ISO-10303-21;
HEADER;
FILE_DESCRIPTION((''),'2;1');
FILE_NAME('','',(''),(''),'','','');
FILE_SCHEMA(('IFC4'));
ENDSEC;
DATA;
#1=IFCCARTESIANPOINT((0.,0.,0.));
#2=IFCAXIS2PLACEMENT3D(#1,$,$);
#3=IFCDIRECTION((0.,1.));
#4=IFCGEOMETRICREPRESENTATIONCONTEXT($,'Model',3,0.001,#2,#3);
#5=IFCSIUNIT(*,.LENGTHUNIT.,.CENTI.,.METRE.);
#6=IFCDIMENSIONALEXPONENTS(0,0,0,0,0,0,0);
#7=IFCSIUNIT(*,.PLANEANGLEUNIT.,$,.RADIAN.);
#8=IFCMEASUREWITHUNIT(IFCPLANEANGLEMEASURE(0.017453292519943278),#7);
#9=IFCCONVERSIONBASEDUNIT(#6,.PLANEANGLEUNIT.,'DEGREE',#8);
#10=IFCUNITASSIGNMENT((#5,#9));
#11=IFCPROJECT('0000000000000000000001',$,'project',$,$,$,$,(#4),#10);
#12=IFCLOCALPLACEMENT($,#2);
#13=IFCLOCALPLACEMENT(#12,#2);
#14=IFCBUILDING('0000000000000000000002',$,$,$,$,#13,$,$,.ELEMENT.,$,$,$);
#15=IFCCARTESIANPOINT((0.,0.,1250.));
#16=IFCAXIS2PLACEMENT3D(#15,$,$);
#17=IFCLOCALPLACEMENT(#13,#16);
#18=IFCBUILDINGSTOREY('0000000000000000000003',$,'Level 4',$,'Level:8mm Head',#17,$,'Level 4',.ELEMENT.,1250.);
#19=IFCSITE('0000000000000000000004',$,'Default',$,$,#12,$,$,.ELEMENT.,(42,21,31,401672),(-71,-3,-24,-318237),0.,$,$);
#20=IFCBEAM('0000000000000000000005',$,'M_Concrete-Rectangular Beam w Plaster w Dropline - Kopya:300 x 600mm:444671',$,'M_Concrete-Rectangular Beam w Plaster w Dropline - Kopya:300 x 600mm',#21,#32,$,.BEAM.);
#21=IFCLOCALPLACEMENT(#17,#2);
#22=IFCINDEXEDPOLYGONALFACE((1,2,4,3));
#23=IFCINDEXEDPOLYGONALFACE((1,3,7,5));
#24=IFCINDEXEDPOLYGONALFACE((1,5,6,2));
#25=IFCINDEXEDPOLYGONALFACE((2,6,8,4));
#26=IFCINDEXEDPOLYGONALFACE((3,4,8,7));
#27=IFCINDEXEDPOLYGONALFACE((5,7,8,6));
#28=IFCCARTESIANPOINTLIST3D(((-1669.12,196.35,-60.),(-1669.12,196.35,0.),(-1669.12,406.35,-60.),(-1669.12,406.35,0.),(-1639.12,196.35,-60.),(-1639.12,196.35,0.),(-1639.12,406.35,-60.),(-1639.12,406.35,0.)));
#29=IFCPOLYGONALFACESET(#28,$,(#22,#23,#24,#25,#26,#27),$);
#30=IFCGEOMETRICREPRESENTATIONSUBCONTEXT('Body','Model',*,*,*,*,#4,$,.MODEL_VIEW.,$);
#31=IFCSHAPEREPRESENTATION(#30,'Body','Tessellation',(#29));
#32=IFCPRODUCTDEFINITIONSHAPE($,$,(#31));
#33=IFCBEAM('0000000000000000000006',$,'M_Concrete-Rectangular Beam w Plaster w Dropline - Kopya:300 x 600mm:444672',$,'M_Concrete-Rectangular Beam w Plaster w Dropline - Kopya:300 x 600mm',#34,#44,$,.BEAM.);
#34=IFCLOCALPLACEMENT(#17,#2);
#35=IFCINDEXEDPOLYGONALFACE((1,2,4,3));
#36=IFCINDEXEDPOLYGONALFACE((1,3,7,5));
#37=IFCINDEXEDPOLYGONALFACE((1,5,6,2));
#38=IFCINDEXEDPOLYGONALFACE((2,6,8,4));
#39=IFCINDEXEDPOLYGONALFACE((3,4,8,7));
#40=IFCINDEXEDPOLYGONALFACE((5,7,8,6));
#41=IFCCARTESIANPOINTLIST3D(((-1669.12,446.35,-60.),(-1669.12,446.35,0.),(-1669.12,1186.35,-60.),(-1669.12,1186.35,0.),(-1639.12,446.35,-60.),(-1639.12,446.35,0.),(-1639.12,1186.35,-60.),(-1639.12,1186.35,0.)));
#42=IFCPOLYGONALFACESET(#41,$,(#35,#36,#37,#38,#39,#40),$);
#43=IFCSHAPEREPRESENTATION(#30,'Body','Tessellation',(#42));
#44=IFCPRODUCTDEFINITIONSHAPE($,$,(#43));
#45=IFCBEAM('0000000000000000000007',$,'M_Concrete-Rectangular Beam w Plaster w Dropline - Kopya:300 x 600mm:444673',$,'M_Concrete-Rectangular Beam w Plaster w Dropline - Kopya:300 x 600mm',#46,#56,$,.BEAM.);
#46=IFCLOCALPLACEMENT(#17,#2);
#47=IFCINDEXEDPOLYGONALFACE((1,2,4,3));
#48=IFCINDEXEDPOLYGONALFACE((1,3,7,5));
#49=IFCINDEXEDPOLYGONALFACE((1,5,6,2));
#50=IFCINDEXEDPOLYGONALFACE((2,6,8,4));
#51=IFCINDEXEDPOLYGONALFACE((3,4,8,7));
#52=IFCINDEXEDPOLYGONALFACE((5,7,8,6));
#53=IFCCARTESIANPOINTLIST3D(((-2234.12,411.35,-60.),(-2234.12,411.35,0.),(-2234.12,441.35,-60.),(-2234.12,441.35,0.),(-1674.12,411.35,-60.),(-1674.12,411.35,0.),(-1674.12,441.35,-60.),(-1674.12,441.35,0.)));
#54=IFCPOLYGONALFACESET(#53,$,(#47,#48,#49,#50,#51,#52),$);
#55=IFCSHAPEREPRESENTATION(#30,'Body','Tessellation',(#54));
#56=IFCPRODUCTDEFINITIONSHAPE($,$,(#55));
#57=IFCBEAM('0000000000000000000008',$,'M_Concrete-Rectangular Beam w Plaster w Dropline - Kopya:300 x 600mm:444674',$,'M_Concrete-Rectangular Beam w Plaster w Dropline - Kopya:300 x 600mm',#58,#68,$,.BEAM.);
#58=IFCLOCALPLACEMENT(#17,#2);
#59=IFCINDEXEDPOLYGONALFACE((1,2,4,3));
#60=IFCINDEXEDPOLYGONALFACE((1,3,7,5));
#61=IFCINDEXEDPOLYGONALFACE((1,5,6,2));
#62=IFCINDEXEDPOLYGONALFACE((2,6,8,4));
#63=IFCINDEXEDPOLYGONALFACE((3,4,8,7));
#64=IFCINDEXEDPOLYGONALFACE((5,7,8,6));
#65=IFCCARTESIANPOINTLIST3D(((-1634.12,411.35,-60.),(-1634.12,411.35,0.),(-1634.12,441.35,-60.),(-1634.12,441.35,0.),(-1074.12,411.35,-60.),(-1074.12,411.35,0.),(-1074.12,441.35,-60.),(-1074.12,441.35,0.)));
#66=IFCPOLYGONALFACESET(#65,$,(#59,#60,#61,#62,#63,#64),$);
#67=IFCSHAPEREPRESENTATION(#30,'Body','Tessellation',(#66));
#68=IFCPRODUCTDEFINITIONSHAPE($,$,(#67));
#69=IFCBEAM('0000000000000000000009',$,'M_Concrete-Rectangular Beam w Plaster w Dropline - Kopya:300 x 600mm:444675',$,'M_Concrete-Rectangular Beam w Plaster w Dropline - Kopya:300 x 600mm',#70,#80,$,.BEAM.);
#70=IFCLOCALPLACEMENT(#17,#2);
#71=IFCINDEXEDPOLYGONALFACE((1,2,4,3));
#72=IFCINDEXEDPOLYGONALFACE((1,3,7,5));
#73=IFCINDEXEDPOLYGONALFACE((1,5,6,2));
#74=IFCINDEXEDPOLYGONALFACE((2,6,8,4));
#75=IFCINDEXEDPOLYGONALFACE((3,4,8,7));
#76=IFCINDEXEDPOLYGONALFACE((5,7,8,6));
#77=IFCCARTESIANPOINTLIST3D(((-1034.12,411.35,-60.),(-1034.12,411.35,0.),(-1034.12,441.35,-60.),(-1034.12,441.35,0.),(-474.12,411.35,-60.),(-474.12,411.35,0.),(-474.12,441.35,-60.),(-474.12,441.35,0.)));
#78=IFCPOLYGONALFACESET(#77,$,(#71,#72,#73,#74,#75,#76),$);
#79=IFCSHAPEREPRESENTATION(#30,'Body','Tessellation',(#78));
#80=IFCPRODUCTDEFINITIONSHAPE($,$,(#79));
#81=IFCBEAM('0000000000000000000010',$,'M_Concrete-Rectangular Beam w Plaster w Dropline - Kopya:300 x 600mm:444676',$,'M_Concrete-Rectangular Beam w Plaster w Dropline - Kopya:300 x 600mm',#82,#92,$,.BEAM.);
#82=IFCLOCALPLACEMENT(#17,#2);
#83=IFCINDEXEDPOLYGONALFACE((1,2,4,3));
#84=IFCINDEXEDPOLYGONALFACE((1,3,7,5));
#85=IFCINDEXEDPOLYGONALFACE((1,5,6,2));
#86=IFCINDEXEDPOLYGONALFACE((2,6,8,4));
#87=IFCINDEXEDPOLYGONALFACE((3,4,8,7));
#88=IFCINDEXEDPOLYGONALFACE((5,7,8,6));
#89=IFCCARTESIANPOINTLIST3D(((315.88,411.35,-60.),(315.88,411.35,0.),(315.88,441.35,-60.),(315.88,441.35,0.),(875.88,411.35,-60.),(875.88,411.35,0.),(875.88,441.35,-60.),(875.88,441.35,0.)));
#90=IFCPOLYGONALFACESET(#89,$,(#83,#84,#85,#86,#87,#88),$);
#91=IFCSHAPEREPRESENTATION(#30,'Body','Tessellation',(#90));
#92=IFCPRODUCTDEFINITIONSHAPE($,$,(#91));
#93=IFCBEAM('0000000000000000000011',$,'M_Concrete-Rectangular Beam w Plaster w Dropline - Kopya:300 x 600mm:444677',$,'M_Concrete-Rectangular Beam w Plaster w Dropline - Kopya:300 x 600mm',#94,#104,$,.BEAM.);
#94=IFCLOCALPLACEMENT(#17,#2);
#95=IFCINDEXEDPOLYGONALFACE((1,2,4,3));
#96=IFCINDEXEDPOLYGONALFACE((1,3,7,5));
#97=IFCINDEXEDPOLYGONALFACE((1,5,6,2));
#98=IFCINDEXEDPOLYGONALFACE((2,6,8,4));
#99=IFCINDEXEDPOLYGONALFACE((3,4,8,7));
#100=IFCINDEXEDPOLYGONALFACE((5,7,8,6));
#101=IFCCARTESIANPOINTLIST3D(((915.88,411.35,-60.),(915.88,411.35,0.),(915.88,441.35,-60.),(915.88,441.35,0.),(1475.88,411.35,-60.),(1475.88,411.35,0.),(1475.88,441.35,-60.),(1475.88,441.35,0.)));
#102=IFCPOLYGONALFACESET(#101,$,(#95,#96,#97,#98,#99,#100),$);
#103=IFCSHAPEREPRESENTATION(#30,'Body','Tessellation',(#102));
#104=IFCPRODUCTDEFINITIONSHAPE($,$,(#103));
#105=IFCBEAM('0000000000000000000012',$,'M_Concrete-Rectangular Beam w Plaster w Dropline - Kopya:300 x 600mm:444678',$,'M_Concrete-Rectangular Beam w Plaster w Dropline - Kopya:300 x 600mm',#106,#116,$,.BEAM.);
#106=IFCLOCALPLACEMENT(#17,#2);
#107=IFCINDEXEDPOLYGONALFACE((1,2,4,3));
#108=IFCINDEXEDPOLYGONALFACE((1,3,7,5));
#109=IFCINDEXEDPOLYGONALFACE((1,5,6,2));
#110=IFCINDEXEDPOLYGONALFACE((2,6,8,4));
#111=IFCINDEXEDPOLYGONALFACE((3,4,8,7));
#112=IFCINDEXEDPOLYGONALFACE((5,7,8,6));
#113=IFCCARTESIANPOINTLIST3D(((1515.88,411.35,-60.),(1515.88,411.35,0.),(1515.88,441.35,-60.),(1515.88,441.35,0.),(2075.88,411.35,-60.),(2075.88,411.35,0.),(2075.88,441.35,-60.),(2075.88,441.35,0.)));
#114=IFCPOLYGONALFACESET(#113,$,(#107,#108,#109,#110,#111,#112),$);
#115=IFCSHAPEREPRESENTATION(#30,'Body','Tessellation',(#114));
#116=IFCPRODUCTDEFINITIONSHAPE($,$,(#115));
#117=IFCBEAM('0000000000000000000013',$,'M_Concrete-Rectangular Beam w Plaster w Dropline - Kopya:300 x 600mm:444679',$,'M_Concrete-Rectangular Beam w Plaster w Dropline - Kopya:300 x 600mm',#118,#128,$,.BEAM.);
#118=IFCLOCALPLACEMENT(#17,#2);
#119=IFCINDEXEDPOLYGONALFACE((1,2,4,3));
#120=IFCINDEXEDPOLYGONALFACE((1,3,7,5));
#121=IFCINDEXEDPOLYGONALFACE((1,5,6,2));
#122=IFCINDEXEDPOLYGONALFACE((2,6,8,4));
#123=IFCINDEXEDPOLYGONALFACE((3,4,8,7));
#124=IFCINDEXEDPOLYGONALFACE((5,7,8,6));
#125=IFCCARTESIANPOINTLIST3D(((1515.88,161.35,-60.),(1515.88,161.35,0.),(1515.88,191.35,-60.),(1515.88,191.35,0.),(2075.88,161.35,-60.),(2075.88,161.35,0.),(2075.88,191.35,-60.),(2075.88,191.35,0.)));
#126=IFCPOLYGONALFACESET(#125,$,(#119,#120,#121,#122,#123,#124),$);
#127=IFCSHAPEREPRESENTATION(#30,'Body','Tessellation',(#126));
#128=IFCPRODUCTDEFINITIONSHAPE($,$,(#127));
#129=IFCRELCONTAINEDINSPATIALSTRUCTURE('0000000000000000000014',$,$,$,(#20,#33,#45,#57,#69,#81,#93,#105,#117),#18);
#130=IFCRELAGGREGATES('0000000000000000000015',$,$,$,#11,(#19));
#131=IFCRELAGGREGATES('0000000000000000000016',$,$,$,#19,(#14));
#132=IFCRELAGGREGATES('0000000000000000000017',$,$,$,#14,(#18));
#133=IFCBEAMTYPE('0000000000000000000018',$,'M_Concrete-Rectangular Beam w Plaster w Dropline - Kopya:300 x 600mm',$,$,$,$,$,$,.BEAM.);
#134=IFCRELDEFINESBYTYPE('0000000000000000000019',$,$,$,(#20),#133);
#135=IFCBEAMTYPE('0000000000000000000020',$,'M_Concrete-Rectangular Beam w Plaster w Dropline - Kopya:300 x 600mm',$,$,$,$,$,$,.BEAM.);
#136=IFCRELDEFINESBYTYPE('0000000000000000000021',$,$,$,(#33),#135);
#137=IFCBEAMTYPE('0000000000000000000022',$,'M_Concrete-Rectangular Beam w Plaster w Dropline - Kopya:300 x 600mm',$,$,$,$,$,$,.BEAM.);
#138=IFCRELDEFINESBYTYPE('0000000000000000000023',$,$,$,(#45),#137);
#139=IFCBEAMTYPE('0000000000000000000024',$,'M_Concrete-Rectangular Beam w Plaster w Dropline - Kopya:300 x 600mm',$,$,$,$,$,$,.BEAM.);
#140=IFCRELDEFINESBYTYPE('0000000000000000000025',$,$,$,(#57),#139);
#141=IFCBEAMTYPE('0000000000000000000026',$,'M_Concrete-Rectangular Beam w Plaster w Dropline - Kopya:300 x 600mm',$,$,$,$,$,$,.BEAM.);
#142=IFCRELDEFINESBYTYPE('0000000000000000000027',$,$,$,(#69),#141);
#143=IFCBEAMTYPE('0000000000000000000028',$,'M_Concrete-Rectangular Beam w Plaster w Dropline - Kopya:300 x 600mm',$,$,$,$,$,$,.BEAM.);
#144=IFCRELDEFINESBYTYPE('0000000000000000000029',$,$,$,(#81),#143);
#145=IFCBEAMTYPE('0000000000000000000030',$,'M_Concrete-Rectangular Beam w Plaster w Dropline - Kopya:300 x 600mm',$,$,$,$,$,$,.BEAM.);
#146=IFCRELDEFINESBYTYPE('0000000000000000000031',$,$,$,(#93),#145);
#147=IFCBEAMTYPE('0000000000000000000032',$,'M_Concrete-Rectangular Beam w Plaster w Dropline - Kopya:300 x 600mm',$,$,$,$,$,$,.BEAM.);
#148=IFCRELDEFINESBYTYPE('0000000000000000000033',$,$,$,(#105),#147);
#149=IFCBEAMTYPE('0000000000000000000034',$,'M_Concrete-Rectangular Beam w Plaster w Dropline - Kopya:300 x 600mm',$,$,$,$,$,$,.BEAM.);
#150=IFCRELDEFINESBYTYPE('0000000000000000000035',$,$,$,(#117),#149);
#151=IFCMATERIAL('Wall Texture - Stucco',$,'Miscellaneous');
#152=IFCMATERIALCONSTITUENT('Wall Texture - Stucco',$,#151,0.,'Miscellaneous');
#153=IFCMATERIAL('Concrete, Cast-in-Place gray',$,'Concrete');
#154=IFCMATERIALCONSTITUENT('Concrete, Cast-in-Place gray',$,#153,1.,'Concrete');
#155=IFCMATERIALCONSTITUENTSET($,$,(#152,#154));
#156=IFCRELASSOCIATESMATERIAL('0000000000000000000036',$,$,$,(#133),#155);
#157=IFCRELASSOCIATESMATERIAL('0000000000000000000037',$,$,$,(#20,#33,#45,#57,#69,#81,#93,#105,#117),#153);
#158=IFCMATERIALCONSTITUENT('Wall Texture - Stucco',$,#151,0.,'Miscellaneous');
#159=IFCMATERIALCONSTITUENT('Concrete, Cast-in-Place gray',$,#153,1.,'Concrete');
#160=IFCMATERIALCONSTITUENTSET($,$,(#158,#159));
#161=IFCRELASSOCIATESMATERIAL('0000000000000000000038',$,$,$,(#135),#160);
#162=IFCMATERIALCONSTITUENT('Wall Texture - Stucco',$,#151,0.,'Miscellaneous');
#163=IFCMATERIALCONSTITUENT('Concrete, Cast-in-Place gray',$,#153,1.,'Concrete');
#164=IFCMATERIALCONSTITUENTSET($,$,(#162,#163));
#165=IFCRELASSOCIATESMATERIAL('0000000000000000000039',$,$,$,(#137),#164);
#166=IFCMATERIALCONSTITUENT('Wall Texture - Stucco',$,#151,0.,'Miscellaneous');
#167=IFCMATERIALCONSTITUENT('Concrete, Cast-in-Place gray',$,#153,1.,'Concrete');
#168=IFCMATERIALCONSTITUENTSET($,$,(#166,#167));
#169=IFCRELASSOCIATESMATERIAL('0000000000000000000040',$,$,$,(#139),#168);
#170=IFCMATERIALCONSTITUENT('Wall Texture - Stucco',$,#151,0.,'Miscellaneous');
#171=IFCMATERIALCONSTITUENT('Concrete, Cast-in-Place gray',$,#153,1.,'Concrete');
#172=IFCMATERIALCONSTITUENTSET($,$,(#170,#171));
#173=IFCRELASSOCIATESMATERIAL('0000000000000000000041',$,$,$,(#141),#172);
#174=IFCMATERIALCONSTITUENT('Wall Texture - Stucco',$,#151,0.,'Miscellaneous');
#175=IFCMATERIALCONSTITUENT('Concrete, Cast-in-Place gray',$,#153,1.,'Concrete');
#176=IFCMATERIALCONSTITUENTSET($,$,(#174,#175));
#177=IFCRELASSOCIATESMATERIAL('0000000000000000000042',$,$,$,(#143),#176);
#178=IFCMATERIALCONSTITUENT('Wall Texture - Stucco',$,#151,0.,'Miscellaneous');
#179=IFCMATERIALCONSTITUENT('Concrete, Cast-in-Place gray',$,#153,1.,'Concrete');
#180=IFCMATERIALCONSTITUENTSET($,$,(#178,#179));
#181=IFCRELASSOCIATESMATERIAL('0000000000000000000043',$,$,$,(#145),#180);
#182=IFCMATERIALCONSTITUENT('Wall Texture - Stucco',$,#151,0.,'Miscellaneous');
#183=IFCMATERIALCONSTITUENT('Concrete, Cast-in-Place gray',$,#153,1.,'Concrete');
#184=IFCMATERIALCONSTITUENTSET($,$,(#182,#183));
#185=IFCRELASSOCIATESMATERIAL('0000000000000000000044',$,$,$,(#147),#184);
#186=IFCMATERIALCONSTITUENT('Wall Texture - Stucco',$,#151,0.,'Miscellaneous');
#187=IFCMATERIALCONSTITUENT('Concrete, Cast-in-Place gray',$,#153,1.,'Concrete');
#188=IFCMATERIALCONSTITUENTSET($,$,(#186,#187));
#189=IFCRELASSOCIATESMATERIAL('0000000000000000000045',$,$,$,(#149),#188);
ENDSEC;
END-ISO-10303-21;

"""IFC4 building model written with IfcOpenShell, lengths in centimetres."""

from ifc_helpers import new_model, entity, si_unit, converted_unit, direction, frame, origin, place, context, subcontext, project, spatial, indexed_curve, outline, extrude, source, transform, mapped, material, constituent, constituent_set, type_object, type_shapes, element, save


model = new_model("IFC4")

# Units and contexts
model_context = context("Model", 3, precision=0.001, world=origin(), true_north=direction((0.0, 1.0)))
body_context = subcontext(model_context, "Body", "Model", "MODEL_VIEW")
ifc_project = project(units=[si_unit("LENGTHUNIT", "METRE", prefix="CENTI"), converted_unit("PLANEANGLEUNIT", "DEGREE", entity("IfcPlaneAngleMeasure", 0.017453292519943278), si_unit("PLANEANGLEUNIT", "RADIAN"), dimensions=[0, 0, 0, 0, 0, 0, 0])], contexts=[model_context])

# Site, building, storey
site_placement = place(None, origin())
site = spatial("IfcSite", under=ifc_project, at=site_placement, Name="Default", CompositionType="ELEMENT", RefLatitude=(42, 21, 31, 401672), RefLongitude=(-71, -3, -24, -318237), RefElevation=0.0)
building_placement = place(site_placement, origin())
building = spatial("IfcBuilding", under=site, at=building_placement, CompositionType="ELEMENT")
storey_placement = place(building_placement, frame((0.0, 0.0, 1250.0)))
storey = spatial("IfcBuildingStorey", under=building, at=storey_placement, Name="Level 4", ObjectType="Level:8mm Head", LongName="Level 4", CompositionType="ELEMENT", Elevation=1250.0)

# Shared definitions
ifc_material_1 = material(Name="Concrete, Cast-in-Place gray", Category="Concrete")

# Beams
ifc_material_2 = material(Name="Wall Texture - Stucco", Category="Miscellaneous")
ifc_constituent_1 = constituent(ifc_material_2, Name="Wall Texture - Stucco", Category="Miscellaneous", fraction=0.0)
ifc_constituent_2 = constituent(ifc_material_1, Name="Concrete, Cast-in-Place gray", Category="Concrete", fraction=1.0)
ifc_constituent_set_1 = constituent_set(constituents=[ifc_constituent_1, ifc_constituent_2])
beam_type_1 = type_object("IfcBeamType", Name="M_Concrete-Rectangular Beam w Plaster w Dropline - Kopya:300 x 600mm", PredefinedType="BEAM", material=ifc_constituent_set_1)
shared_shape_1 = source(origin(), body_context, "Body", "SweptSolid", [
    extrude(outline(indexed_curve([(-15.0, -30.0), (15.0, -30.0), (15.0, 30.0), (-15.0, 30.0), (-15.0, -30.0)], self_intersect=False)), frame((-1654.12, 196.35, 1220.0), z_axis=(0.0, 1.0, 0.0), x_axis=(-1.0, 0.0, 0.0)), (0.0, 0.0, 1.0), 210.0),
])
type_shapes(beam_type_1, [shared_shape_1])
beam_1_placement = place(storey_placement, frame((0.0, 0.0, -1250.0)))
element("IfcBeam", 1, at=beam_1_placement, inside=storey, type_object=beam_type_1, material=ifc_material_1, Name="M_Concrete-Rectangular Beam w Plaster w Dropline - Kopya:300 x 600mm:444671", ObjectType="M_Concrete-Rectangular Beam w Plaster w Dropline - Kopya:300 x 600mm", PredefinedType="BEAM", context=body_context, shape_type="MappedRepresentation", body=[
    mapped(shared_shape_1, transform((0.0, 0.0, 0.0), scale=1.0)),
])
ifc_constituent_3 = constituent(ifc_material_2, Name="Wall Texture - Stucco", Category="Miscellaneous", fraction=0.0)
ifc_constituent_4 = constituent(ifc_material_1, Name="Concrete, Cast-in-Place gray", Category="Concrete", fraction=1.0)
ifc_constituent_set_2 = constituent_set(constituents=[ifc_constituent_3, ifc_constituent_4])
beam_type_2 = type_object("IfcBeamType", Name="M_Concrete-Rectangular Beam w Plaster w Dropline - Kopya:300 x 600mm", PredefinedType="BEAM", material=ifc_constituent_set_2)
shared_shape_2 = source(origin(), body_context, "Body", "SweptSolid", [
    extrude(outline(indexed_curve([(-15.0, -30.0), (15.0, -30.0), (15.0, 30.0), (-15.0, 30.0), (-15.0, -30.0)], self_intersect=False)), frame((-1654.12, 446.35, 1220.0), z_axis=(0.0, 1.0, 0.0), x_axis=(-1.0, 0.0, 0.0)), (0.0, 0.0, 1.0), 740.0),
])
type_shapes(beam_type_2, [shared_shape_2])
beam_2_placement = place(storey_placement, frame((0.0, 0.0, -1250.0)))
element("IfcBeam", 2, at=beam_2_placement, inside=storey, type_object=beam_type_2, material=ifc_material_1, Name="M_Concrete-Rectangular Beam w Plaster w Dropline - Kopya:300 x 600mm:444672", ObjectType="M_Concrete-Rectangular Beam w Plaster w Dropline - Kopya:300 x 600mm", PredefinedType="BEAM", context=body_context, shape_type="MappedRepresentation", body=[
    mapped(shared_shape_2, transform((0.0, 0.0, 0.0), scale=1.0)),
])
ifc_constituent_5 = constituent(ifc_material_2, Name="Wall Texture - Stucco", Category="Miscellaneous", fraction=0.0)
ifc_constituent_6 = constituent(ifc_material_1, Name="Concrete, Cast-in-Place gray", Category="Concrete", fraction=1.0)
ifc_constituent_set_3 = constituent_set(constituents=[ifc_constituent_5, ifc_constituent_6])
beam_type_3 = type_object("IfcBeamType", Name="M_Concrete-Rectangular Beam w Plaster w Dropline - Kopya:300 x 600mm", PredefinedType="BEAM", material=ifc_constituent_set_3)
shared_shape_3 = source(origin(), body_context, "Body", "SweptSolid", [
    extrude(outline(indexed_curve([(-30.0, -15.0), (30.0, -15.0), (30.0, 15.0), (-30.0, 15.0), (-30.0, -15.0)], self_intersect=False)), frame((-2234.12, 426.35, 1220.0), z_axis=(1.0, 0.0, 0.0), x_axis=(0.0, 0.0, -1.0)), (0.0, 0.0, 1.0), 560.0),
])
type_shapes(beam_type_3, [shared_shape_3])
beam_3_placement = place(storey_placement, frame((0.0, 0.0, -1250.0)))
element("IfcBeam", 3, at=beam_3_placement, inside=storey, type_object=beam_type_3, material=ifc_material_1, Name="M_Concrete-Rectangular Beam w Plaster w Dropline - Kopya:300 x 600mm:444673", ObjectType="M_Concrete-Rectangular Beam w Plaster w Dropline - Kopya:300 x 600mm", PredefinedType="BEAM", context=body_context, shape_type="MappedRepresentation", body=[
    mapped(shared_shape_3, transform((0.0, 0.0, 0.0), scale=1.0)),
])
ifc_constituent_7 = constituent(ifc_material_2, Name="Wall Texture - Stucco", Category="Miscellaneous", fraction=0.0)
ifc_constituent_8 = constituent(ifc_material_1, Name="Concrete, Cast-in-Place gray", Category="Concrete", fraction=1.0)
ifc_constituent_set_4 = constituent_set(constituents=[ifc_constituent_7, ifc_constituent_8])
beam_type_4 = type_object("IfcBeamType", Name="M_Concrete-Rectangular Beam w Plaster w Dropline - Kopya:300 x 600mm", PredefinedType="BEAM", material=ifc_constituent_set_4)
shared_shape_4 = source(origin(), body_context, "Body", "SweptSolid", [
    extrude(outline(indexed_curve([(-30.0, -15.0), (30.0, -15.0), (30.0, 15.0), (-30.0, 15.0), (-30.0, -15.0)], self_intersect=False)), frame((-1634.12, 426.35, 1220.0), z_axis=(1.0, 0.0, 0.0), x_axis=(0.0, 0.0, -1.0)), (0.0, 0.0, 1.0), 560.0),
])
type_shapes(beam_type_4, [shared_shape_4])
beam_4_placement = place(storey_placement, frame((0.0, 0.0, -1250.0)))
element("IfcBeam", 4, at=beam_4_placement, inside=storey, type_object=beam_type_4, material=ifc_material_1, Name="M_Concrete-Rectangular Beam w Plaster w Dropline - Kopya:300 x 600mm:444674", ObjectType="M_Concrete-Rectangular Beam w Plaster w Dropline - Kopya:300 x 600mm", PredefinedType="BEAM", context=body_context, shape_type="MappedRepresentation", body=[
    mapped(shared_shape_4, transform((0.0, 0.0, 0.0), scale=1.0)),
])
ifc_constituent_9 = constituent(ifc_material_2, Name="Wall Texture - Stucco", Category="Miscellaneous", fraction=0.0)
ifc_constituent_10 = constituent(ifc_material_1, Name="Concrete, Cast-in-Place gray", Category="Concrete", fraction=1.0)
ifc_constituent_set_5 = constituent_set(constituents=[ifc_constituent_9, ifc_constituent_10])
beam_type_5 = type_object("IfcBeamType", Name="M_Concrete-Rectangular Beam w Plaster w Dropline - Kopya:300 x 600mm", PredefinedType="BEAM", material=ifc_constituent_set_5)
shared_shape_5 = source(origin(), body_context, "Body", "SweptSolid", [
    extrude(outline(indexed_curve([(-30.0, -15.0), (30.0, -15.0), (30.0, 15.0), (-30.0, 15.0), (-30.0, -15.0)], self_intersect=False)), frame((-1034.12, 426.35, 1220.0), z_axis=(1.0, 0.0, 0.0), x_axis=(0.0, 0.0, -1.0)), (0.0, 0.0, 1.0), 560.0),
])
type_shapes(beam_type_5, [shared_shape_5])
beam_5_placement = place(storey_placement, frame((0.0, 0.0, -1250.0)))
element("IfcBeam", 5, at=beam_5_placement, inside=storey, type_object=beam_type_5, material=ifc_material_1, Name="M_Concrete-Rectangular Beam w Plaster w Dropline - Kopya:300 x 600mm:444675", ObjectType="M_Concrete-Rectangular Beam w Plaster w Dropline - Kopya:300 x 600mm", PredefinedType="BEAM", context=body_context, shape_type="MappedRepresentation", body=[
    mapped(shared_shape_5, transform((0.0, 0.0, 0.0), scale=1.0)),
])
ifc_constituent_11 = constituent(ifc_material_2, Name="Wall Texture - Stucco", Category="Miscellaneous", fraction=0.0)
ifc_constituent_12 = constituent(ifc_material_1, Name="Concrete, Cast-in-Place gray", Category="Concrete", fraction=1.0)
ifc_constituent_set_6 = constituent_set(constituents=[ifc_constituent_11, ifc_constituent_12])
beam_type_6 = type_object("IfcBeamType", Name="M_Concrete-Rectangular Beam w Plaster w Dropline - Kopya:300 x 600mm", PredefinedType="BEAM", material=ifc_constituent_set_6)
shared_shape_6 = source(origin(), body_context, "Body", "SweptSolid", [
    extrude(outline(indexed_curve([(-30.0, -15.0), (30.0, -15.0), (30.0, 15.0), (-30.0, 15.0), (-30.0, -15.0)], self_intersect=False)), frame((315.88, 426.35, 1220.0), z_axis=(1.0, 0.0, 0.0), x_axis=(0.0, 0.0, -1.0)), (0.0, 0.0, 1.0), 560.0),
])
type_shapes(beam_type_6, [shared_shape_6])
beam_6_placement = place(storey_placement, frame((0.0, 0.0, -1250.0)))
element("IfcBeam", 6, at=beam_6_placement, inside=storey, type_object=beam_type_6, material=ifc_material_1, Name="M_Concrete-Rectangular Beam w Plaster w Dropline - Kopya:300 x 600mm:444676", ObjectType="M_Concrete-Rectangular Beam w Plaster w Dropline - Kopya:300 x 600mm", PredefinedType="BEAM", context=body_context, shape_type="MappedRepresentation", body=[
    mapped(shared_shape_6, transform((0.0, 0.0, 0.0), scale=1.0)),
])
ifc_constituent_13 = constituent(ifc_material_2, Name="Wall Texture - Stucco", Category="Miscellaneous", fraction=0.0)
ifc_constituent_14 = constituent(ifc_material_1, Name="Concrete, Cast-in-Place gray", Category="Concrete", fraction=1.0)
ifc_constituent_set_7 = constituent_set(constituents=[ifc_constituent_13, ifc_constituent_14])
beam_type_7 = type_object("IfcBeamType", Name="M_Concrete-Rectangular Beam w Plaster w Dropline - Kopya:300 x 600mm", PredefinedType="BEAM", material=ifc_constituent_set_7)
shared_shape_7 = source(origin(), body_context, "Body", "SweptSolid", [
    extrude(outline(indexed_curve([(-30.0, -15.0), (30.0, -15.0), (30.0, 15.0), (-30.0, 15.0), (-30.0, -15.0)], self_intersect=False)), frame((915.88, 426.35, 1220.0), z_axis=(1.0, 0.0, 0.0), x_axis=(0.0, 0.0, -1.0)), (0.0, 0.0, 1.0), 560.0),
])
type_shapes(beam_type_7, [shared_shape_7])
beam_7_placement = place(storey_placement, frame((0.0, 0.0, -1250.0)))
element("IfcBeam", 7, at=beam_7_placement, inside=storey, type_object=beam_type_7, material=ifc_material_1, Name="M_Concrete-Rectangular Beam w Plaster w Dropline - Kopya:300 x 600mm:444677", ObjectType="M_Concrete-Rectangular Beam w Plaster w Dropline - Kopya:300 x 600mm", PredefinedType="BEAM", context=body_context, shape_type="MappedRepresentation", body=[
    mapped(shared_shape_7, transform((0.0, 0.0, 0.0), scale=1.0)),
])
ifc_constituent_15 = constituent(ifc_material_2, Name="Wall Texture - Stucco", Category="Miscellaneous", fraction=0.0)
ifc_constituent_16 = constituent(ifc_material_1, Name="Concrete, Cast-in-Place gray", Category="Concrete", fraction=1.0)
ifc_constituent_set_8 = constituent_set(constituents=[ifc_constituent_15, ifc_constituent_16])
beam_type_8 = type_object("IfcBeamType", Name="M_Concrete-Rectangular Beam w Plaster w Dropline - Kopya:300 x 600mm", PredefinedType="BEAM", material=ifc_constituent_set_8)
shared_shape_8 = source(origin(), body_context, "Body", "SweptSolid", [
    extrude(outline(indexed_curve([(-30.0, -15.0), (30.0, -15.0), (30.0, 15.0), (-30.0, 15.0), (-30.0, -15.0)], self_intersect=False)), frame((1515.88, 426.35, 1220.0), z_axis=(1.0, 0.0, 0.0), x_axis=(0.0, 0.0, -1.0)), (0.0, 0.0, 1.0), 560.0),
])
type_shapes(beam_type_8, [shared_shape_8])
beam_8_placement = place(storey_placement, frame((0.0, 0.0, -1250.0)))
element("IfcBeam", 8, at=beam_8_placement, inside=storey, type_object=beam_type_8, material=ifc_material_1, Name="M_Concrete-Rectangular Beam w Plaster w Dropline - Kopya:300 x 600mm:444678", ObjectType="M_Concrete-Rectangular Beam w Plaster w Dropline - Kopya:300 x 600mm", PredefinedType="BEAM", context=body_context, shape_type="MappedRepresentation", body=[
    mapped(shared_shape_8, transform((0.0, 0.0, 0.0), scale=1.0)),
])
ifc_constituent_17 = constituent(ifc_material_2, Name="Wall Texture - Stucco", Category="Miscellaneous", fraction=0.0)
ifc_constituent_18 = constituent(ifc_material_1, Name="Concrete, Cast-in-Place gray", Category="Concrete", fraction=1.0)
ifc_constituent_set_9 = constituent_set(constituents=[ifc_constituent_17, ifc_constituent_18])
beam_type_9 = type_object("IfcBeamType", Name="M_Concrete-Rectangular Beam w Plaster w Dropline - Kopya:300 x 600mm", PredefinedType="BEAM", material=ifc_constituent_set_9)
shared_shape_9 = source(origin(), body_context, "Body", "SweptSolid", [
    extrude(outline(indexed_curve([(-30.0, -15.0), (30.0, -15.0), (30.0, 15.0), (-30.0, 15.0), (-30.0, -15.0)], self_intersect=False)), frame((2075.88, 176.35, 1220.0), z_axis=(-1.0, 0.0, 0.0), x_axis=(0.0, 0.0, -1.0)), (0.0, 0.0, 1.0), 560.0),
])
type_shapes(beam_type_9, [shared_shape_9])
beam_9_placement = place(storey_placement, frame((0.0, 0.0, -1250.0)))
element("IfcBeam", 9, at=beam_9_placement, inside=storey, type_object=beam_type_9, material=ifc_material_1, Name="M_Concrete-Rectangular Beam w Plaster w Dropline - Kopya:300 x 600mm:444679", ObjectType="M_Concrete-Rectangular Beam w Plaster w Dropline - Kopya:300 x 600mm", PredefinedType="BEAM", context=body_context, shape_type="MappedRepresentation", body=[
    mapped(shared_shape_9, transform((0.0, 0.0, 0.0), scale=1.0)),
])

save(model, "model.ifc")
